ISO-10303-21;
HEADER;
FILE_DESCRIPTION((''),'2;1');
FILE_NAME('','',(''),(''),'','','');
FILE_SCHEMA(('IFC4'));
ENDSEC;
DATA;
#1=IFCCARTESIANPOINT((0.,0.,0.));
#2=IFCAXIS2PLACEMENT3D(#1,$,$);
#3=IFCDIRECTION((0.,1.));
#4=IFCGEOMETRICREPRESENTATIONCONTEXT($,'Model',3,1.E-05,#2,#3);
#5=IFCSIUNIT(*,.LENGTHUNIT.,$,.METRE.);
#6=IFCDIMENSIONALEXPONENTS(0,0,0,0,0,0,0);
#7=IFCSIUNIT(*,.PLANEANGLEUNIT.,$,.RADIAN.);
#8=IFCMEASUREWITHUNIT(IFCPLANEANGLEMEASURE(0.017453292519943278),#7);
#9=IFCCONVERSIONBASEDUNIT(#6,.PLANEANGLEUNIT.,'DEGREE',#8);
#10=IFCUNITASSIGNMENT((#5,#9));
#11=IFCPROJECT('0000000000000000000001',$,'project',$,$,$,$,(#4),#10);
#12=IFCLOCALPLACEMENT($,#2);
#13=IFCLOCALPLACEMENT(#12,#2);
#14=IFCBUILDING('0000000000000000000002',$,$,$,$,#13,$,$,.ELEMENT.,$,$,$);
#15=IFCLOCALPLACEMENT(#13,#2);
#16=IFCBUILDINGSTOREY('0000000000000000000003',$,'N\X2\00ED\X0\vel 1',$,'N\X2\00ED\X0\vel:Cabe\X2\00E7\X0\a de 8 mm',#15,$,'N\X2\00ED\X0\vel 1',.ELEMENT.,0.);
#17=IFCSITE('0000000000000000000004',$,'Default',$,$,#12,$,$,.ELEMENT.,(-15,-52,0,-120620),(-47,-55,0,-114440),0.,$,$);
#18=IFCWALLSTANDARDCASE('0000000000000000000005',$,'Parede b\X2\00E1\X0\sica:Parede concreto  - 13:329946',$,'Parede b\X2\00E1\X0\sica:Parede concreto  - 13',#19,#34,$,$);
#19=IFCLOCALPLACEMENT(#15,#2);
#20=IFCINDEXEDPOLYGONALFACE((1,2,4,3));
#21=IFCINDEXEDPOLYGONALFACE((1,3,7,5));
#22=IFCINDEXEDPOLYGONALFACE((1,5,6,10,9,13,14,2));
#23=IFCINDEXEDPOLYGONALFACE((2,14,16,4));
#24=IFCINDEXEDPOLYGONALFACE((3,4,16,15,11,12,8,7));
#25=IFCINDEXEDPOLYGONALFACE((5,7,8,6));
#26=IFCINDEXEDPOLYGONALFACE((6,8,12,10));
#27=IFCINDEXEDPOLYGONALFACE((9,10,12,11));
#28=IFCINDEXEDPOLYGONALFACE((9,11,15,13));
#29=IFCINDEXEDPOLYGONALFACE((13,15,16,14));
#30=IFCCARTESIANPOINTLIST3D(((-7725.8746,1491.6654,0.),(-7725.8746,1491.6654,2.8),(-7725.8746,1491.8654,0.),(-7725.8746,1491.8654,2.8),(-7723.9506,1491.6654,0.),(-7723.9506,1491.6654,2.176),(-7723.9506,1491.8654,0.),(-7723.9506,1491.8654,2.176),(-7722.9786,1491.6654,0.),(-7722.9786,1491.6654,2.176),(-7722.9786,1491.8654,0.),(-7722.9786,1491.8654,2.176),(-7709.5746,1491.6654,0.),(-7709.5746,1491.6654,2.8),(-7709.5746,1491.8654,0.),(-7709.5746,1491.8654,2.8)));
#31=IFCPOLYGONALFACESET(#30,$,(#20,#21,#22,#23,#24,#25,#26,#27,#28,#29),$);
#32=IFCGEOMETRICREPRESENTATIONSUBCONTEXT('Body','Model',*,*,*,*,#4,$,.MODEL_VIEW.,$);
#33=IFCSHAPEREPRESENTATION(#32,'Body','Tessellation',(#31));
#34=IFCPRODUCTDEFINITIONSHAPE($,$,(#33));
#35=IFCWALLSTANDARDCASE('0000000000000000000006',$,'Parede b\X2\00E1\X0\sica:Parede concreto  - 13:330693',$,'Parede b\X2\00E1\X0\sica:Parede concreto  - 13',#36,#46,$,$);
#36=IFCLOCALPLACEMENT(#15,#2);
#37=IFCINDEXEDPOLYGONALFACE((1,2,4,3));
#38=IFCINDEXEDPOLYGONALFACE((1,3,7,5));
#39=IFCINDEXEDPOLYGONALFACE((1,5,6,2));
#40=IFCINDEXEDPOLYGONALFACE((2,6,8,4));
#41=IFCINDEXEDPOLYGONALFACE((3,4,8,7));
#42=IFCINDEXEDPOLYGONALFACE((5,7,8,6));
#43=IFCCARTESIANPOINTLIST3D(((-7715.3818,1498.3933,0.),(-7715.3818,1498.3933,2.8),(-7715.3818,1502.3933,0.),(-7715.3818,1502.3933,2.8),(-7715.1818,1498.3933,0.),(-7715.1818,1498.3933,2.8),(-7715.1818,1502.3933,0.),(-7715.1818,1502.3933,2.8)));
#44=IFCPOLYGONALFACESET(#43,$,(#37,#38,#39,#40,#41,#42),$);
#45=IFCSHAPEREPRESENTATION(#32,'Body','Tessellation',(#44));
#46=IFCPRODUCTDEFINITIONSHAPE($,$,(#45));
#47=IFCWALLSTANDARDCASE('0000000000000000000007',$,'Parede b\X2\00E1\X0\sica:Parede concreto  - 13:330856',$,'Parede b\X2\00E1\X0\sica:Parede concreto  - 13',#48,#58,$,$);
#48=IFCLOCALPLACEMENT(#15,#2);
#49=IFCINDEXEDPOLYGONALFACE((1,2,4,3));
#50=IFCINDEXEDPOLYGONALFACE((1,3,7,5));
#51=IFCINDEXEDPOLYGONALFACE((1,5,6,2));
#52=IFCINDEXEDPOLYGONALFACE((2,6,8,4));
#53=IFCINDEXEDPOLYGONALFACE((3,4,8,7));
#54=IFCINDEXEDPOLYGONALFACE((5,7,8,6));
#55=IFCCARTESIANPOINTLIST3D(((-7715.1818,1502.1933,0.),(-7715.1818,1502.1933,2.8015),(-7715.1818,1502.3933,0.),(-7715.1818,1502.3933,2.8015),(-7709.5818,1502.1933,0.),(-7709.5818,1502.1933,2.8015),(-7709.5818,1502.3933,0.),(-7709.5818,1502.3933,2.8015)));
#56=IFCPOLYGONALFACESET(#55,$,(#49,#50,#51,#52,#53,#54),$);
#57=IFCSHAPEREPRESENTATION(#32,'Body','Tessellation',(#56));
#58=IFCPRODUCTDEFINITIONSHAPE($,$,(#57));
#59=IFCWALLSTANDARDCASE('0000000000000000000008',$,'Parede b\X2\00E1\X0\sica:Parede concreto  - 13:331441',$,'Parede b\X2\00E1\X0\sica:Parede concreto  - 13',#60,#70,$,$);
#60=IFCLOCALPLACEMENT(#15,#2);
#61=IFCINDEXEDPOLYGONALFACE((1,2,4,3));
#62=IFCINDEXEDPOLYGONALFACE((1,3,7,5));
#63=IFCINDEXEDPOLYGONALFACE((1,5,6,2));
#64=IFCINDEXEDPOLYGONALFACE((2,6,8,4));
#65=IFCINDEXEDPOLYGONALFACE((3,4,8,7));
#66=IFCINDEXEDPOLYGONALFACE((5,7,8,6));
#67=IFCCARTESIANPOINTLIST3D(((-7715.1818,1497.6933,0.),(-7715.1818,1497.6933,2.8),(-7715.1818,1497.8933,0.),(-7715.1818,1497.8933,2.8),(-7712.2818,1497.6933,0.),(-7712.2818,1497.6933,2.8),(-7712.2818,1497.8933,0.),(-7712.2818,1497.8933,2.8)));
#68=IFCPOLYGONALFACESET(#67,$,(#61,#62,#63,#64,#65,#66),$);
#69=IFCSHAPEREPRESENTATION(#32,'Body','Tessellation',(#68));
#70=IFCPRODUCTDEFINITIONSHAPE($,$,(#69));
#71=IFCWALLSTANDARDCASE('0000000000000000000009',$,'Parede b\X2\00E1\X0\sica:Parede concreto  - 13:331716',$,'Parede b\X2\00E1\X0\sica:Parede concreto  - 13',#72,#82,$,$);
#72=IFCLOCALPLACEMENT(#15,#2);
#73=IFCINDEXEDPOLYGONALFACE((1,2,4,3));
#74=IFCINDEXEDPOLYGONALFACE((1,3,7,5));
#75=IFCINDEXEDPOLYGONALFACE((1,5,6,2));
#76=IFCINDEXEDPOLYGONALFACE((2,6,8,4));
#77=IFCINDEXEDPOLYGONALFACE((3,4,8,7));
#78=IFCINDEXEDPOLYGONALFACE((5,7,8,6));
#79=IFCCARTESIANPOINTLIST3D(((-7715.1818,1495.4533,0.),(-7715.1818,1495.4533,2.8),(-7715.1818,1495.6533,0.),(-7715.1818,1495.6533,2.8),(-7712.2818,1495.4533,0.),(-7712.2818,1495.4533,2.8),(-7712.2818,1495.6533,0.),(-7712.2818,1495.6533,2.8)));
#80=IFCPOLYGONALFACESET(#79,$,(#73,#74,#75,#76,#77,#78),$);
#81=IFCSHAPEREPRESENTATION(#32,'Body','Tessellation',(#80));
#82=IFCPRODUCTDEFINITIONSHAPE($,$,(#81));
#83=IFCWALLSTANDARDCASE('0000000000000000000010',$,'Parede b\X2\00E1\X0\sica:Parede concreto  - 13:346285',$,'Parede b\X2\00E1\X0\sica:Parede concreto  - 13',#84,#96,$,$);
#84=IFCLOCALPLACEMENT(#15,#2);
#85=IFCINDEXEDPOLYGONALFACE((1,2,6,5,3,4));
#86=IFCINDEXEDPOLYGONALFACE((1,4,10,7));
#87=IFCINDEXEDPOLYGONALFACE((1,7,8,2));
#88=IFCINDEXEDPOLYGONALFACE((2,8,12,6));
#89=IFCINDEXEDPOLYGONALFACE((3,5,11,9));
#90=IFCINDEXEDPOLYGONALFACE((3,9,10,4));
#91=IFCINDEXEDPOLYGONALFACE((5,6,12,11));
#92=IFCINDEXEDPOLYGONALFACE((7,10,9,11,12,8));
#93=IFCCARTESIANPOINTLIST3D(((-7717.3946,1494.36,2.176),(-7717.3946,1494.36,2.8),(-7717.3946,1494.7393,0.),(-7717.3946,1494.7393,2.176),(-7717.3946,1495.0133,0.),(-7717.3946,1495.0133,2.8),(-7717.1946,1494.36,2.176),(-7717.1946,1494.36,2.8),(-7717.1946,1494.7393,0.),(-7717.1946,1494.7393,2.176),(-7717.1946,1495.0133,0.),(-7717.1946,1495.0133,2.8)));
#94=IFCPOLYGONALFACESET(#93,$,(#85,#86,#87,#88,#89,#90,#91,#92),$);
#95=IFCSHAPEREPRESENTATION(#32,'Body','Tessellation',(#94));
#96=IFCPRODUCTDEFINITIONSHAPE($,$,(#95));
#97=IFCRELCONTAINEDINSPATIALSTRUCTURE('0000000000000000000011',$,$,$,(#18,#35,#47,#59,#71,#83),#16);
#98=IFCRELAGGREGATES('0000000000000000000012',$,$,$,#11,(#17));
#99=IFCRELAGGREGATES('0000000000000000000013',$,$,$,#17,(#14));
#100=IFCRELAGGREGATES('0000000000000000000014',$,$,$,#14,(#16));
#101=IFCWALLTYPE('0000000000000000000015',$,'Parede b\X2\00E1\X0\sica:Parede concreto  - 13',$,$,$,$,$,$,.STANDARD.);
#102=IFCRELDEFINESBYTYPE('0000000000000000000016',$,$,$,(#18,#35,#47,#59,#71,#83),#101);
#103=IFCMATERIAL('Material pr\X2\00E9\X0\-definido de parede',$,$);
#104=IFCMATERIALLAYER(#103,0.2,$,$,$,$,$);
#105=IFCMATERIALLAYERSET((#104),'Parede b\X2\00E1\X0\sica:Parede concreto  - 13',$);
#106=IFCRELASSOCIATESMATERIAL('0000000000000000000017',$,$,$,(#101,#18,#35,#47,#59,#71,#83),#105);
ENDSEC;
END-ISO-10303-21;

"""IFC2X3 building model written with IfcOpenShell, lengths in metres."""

from ifc_helpers import new_model, entity, si_unit, converted_unit, direction, frame, frame_2d, origin, place, context, subcontext, project, spatial, rectangle, extrude, material, layer, layer_set, layer_usage, type_object, element, save


model = new_model("IFC2X3")

# Units and contexts
model_context = context("Model", 3, precision=1e-05, world=origin(), true_north=direction((0.0, 1.0)))
body_context = subcontext(model_context, "Body", "Model", "MODEL_VIEW")
ifc_project = project(units=[si_unit("LENGTHUNIT", "METRE"), converted_unit("PLANEANGLEUNIT", "DEGREE", entity("IfcPlaneAngleMeasure", 0.017453292519943278), si_unit("PLANEANGLEUNIT", "RADIAN"), dimensions=[0, 0, 0, 0, 0, 0, 0])], contexts=[model_context])

# Site, building, storey
site_placement = place(None, origin())
site = spatial("IfcSite", under=ifc_project, at=site_placement, Name="Default", CompositionType="ELEMENT", RefLatitude=(-15, -52, 0, -120620), RefLongitude=(-47, -55, 0, -114440), RefElevation=0.0)
building_placement = place(site_placement, origin())
building = spatial("IfcBuilding", under=site, at=building_placement, CompositionType="ELEMENT")
storey_placement = place(building_placement, origin())
storey = spatial("IfcBuildingStorey", under=building, at=storey_placement, Name="Nível 1", ObjectType="Nível:Cabeça de 8 mm", LongName="Nível 1", CompositionType="ELEMENT", Elevation=0.0)

# Shared definitions
ifc_material_1 = material(Name="Material pré-definido de parede")
ifc_layer = layer(ifc_material_1, 0.2)
ifc_layer_set = layer_set([ifc_layer], Name="Parede básica:Parede concreto  - 13")
wall_type = type_object("IfcWallType", Name="Parede básica:Parede concreto  - 13", PredefinedType="STANDARD", material=ifc_layer_set)

# Wall, opening
ifc_layer_usage_1 = layer_usage(ifc_layer_set, "AXIS2", "NEGATIVE", 0.1)
wall_1_placement = place(storey_placement, frame((-7725.8746, 1491.7654, 0.0)))
wall_1 = element("IfcWallStandardCase", 1, at=wall_1_placement, inside=storey, type_object=wall_type, material=ifc_layer_usage_1, Name="Parede básica:Parede concreto  - 13:329946", ObjectType="Parede básica:Parede concreto  - 13", context=body_context, shape_type="SweptSolid", body=[
    extrude(rectangle(XDim=16.3, YDim=0.2, at=frame_2d((8.15, 0.0), x_axis=(-1.0, 0.0))), origin(), (0.0, 0.0, 1.0), 2.8),
])
opening_1_placement = place(wall_1_placement, origin())
element("IfcOpeningElement", 2, at=opening_1_placement, cuts=wall_1, ObjectType="Opening", context=body_context, shape_type="SweptSolid", body=[
    extrude(rectangle(XDim=2.176, YDim=0.972, at=frame_2d((0.0, 0.0), x_axis=(0.0, 1.0))), frame((2.41, 0.1, 1.088), z_axis=(0.0, -1.0, 0.0), x_axis=(1.0, 0.0, 0.0)), (0.0, 0.0, 1.0), 0.2),
])

# Walls
ifc_layer_usage_2 = layer_usage(ifc_layer_set, "AXIS2", "NEGATIVE", 0.1)
wall_2_placement = place(storey_placement, frame((-7715.2818, 1498.3933, 0.0), z_axis=(0.0, 0.0, 1.0), x_axis=(0.0, 1.0, 0.0)))
element("IfcWallStandardCase", 3, at=wall_2_placement, inside=storey, type_object=wall_type, material=ifc_layer_usage_2, Name="Parede básica:Parede concreto  - 13:330693", ObjectType="Parede básica:Parede concreto  - 13", context=body_context, shape_type="SweptSolid", body=[
    extrude(rectangle(XDim=4.0, YDim=0.2, at=frame_2d((2.0, 0.0), x_axis=(-1.0, 0.0))), origin(), (0.0, 0.0, 1.0), 2.8),
])
ifc_layer_usage_3 = layer_usage(ifc_layer_set, "AXIS2", "NEGATIVE", 0.1)
wall_3_placement = place(storey_placement, frame((-7715.1818, 1502.2933, 0.0)))
element("IfcWallStandardCase", 4, at=wall_3_placement, inside=storey, type_object=wall_type, material=ifc_layer_usage_3, Name="Parede básica:Parede concreto  - 13:330856", ObjectType="Parede básica:Parede concreto  - 13", context=body_context, shape_type="SweptSolid", body=[
    extrude(rectangle(XDim=5.6, YDim=0.2, at=frame_2d((2.8, 0.0), x_axis=(-1.0, 0.0))), origin(), (0.0, 0.0, 1.0), 2.8015),
])
ifc_layer_usage_4 = layer_usage(ifc_layer_set, "AXIS2", "NEGATIVE", 0.1)
wall_4_placement = place(storey_placement, frame((-7715.1818, 1497.7933, 0.0)))
element("IfcWallStandardCase", 5, at=wall_4_placement, inside=storey, type_object=wall_type, material=ifc_layer_usage_4, Name="Parede básica:Parede concreto  - 13:331441", ObjectType="Parede básica:Parede concreto  - 13", context=body_context, shape_type="SweptSolid", body=[
    extrude(rectangle(XDim=2.9, YDim=0.2, at=frame_2d((1.45, 0.0), x_axis=(-1.0, 0.0))), origin(), (0.0, 0.0, 1.0), 2.8),
])
ifc_layer_usage_5 = layer_usage(ifc_layer_set, "AXIS2", "NEGATIVE", 0.1)
wall_5_placement = place(storey_placement, frame((-7715.1818, 1495.5533, 0.0)))
element("IfcWallStandardCase", 6, at=wall_5_placement, inside=storey, type_object=wall_type, material=ifc_layer_usage_5, Name="Parede básica:Parede concreto  - 13:331716", ObjectType="Parede básica:Parede concreto  - 13", context=body_context, shape_type="SweptSolid", body=[
    extrude(rectangle(XDim=2.9, YDim=0.2, at=frame_2d((1.45, 0.0), x_axis=(-1.0, 0.0))), origin(), (0.0, 0.0, 1.0), 2.8),
])

# Wall, opening
ifc_layer_usage_6 = layer_usage(ifc_layer_set, "AXIS2", "POSITIVE", -0.1)
wall_6_placement = place(storey_placement, frame((-7717.2946, 1495.0133, 0.0), z_axis=(0.0, 0.0, 1.0), x_axis=(0.0, -1.0, 0.0)))
wall_6 = element("IfcWallStandardCase", 7, at=wall_6_placement, inside=storey, type_object=wall_type, material=ifc_layer_usage_6, Name="Parede básica:Parede concreto  - 13:346285", ObjectType="Parede básica:Parede concreto  - 13", context=body_context, shape_type="SweptSolid", body=[
    extrude(rectangle(XDim=0.6533, YDim=0.2, at=frame_2d((0.3266, 0.0), x_axis=(-1.0, 0.0))), origin(), (0.0, 0.0, 1.0), 2.8),
])
opening_2_placement = place(wall_6_placement, origin())
element("IfcOpeningElement", 8, at=opening_2_placement, cuts=wall_6, ObjectType="Opening", context=body_context, shape_type="SweptSolid", body=[
    extrude(rectangle(XDim=2.176, YDim=0.3793, at=frame_2d((0.0, 0.0), x_axis=(0.0, 1.0))), frame((0.4636, 0.1, 1.088), z_axis=(0.0, -1.0, 0.0), x_axis=(1.0, 0.0, 0.0)), (0.0, 0.0, 1.0), 0.2),
])

save(model, "model.ifc")
